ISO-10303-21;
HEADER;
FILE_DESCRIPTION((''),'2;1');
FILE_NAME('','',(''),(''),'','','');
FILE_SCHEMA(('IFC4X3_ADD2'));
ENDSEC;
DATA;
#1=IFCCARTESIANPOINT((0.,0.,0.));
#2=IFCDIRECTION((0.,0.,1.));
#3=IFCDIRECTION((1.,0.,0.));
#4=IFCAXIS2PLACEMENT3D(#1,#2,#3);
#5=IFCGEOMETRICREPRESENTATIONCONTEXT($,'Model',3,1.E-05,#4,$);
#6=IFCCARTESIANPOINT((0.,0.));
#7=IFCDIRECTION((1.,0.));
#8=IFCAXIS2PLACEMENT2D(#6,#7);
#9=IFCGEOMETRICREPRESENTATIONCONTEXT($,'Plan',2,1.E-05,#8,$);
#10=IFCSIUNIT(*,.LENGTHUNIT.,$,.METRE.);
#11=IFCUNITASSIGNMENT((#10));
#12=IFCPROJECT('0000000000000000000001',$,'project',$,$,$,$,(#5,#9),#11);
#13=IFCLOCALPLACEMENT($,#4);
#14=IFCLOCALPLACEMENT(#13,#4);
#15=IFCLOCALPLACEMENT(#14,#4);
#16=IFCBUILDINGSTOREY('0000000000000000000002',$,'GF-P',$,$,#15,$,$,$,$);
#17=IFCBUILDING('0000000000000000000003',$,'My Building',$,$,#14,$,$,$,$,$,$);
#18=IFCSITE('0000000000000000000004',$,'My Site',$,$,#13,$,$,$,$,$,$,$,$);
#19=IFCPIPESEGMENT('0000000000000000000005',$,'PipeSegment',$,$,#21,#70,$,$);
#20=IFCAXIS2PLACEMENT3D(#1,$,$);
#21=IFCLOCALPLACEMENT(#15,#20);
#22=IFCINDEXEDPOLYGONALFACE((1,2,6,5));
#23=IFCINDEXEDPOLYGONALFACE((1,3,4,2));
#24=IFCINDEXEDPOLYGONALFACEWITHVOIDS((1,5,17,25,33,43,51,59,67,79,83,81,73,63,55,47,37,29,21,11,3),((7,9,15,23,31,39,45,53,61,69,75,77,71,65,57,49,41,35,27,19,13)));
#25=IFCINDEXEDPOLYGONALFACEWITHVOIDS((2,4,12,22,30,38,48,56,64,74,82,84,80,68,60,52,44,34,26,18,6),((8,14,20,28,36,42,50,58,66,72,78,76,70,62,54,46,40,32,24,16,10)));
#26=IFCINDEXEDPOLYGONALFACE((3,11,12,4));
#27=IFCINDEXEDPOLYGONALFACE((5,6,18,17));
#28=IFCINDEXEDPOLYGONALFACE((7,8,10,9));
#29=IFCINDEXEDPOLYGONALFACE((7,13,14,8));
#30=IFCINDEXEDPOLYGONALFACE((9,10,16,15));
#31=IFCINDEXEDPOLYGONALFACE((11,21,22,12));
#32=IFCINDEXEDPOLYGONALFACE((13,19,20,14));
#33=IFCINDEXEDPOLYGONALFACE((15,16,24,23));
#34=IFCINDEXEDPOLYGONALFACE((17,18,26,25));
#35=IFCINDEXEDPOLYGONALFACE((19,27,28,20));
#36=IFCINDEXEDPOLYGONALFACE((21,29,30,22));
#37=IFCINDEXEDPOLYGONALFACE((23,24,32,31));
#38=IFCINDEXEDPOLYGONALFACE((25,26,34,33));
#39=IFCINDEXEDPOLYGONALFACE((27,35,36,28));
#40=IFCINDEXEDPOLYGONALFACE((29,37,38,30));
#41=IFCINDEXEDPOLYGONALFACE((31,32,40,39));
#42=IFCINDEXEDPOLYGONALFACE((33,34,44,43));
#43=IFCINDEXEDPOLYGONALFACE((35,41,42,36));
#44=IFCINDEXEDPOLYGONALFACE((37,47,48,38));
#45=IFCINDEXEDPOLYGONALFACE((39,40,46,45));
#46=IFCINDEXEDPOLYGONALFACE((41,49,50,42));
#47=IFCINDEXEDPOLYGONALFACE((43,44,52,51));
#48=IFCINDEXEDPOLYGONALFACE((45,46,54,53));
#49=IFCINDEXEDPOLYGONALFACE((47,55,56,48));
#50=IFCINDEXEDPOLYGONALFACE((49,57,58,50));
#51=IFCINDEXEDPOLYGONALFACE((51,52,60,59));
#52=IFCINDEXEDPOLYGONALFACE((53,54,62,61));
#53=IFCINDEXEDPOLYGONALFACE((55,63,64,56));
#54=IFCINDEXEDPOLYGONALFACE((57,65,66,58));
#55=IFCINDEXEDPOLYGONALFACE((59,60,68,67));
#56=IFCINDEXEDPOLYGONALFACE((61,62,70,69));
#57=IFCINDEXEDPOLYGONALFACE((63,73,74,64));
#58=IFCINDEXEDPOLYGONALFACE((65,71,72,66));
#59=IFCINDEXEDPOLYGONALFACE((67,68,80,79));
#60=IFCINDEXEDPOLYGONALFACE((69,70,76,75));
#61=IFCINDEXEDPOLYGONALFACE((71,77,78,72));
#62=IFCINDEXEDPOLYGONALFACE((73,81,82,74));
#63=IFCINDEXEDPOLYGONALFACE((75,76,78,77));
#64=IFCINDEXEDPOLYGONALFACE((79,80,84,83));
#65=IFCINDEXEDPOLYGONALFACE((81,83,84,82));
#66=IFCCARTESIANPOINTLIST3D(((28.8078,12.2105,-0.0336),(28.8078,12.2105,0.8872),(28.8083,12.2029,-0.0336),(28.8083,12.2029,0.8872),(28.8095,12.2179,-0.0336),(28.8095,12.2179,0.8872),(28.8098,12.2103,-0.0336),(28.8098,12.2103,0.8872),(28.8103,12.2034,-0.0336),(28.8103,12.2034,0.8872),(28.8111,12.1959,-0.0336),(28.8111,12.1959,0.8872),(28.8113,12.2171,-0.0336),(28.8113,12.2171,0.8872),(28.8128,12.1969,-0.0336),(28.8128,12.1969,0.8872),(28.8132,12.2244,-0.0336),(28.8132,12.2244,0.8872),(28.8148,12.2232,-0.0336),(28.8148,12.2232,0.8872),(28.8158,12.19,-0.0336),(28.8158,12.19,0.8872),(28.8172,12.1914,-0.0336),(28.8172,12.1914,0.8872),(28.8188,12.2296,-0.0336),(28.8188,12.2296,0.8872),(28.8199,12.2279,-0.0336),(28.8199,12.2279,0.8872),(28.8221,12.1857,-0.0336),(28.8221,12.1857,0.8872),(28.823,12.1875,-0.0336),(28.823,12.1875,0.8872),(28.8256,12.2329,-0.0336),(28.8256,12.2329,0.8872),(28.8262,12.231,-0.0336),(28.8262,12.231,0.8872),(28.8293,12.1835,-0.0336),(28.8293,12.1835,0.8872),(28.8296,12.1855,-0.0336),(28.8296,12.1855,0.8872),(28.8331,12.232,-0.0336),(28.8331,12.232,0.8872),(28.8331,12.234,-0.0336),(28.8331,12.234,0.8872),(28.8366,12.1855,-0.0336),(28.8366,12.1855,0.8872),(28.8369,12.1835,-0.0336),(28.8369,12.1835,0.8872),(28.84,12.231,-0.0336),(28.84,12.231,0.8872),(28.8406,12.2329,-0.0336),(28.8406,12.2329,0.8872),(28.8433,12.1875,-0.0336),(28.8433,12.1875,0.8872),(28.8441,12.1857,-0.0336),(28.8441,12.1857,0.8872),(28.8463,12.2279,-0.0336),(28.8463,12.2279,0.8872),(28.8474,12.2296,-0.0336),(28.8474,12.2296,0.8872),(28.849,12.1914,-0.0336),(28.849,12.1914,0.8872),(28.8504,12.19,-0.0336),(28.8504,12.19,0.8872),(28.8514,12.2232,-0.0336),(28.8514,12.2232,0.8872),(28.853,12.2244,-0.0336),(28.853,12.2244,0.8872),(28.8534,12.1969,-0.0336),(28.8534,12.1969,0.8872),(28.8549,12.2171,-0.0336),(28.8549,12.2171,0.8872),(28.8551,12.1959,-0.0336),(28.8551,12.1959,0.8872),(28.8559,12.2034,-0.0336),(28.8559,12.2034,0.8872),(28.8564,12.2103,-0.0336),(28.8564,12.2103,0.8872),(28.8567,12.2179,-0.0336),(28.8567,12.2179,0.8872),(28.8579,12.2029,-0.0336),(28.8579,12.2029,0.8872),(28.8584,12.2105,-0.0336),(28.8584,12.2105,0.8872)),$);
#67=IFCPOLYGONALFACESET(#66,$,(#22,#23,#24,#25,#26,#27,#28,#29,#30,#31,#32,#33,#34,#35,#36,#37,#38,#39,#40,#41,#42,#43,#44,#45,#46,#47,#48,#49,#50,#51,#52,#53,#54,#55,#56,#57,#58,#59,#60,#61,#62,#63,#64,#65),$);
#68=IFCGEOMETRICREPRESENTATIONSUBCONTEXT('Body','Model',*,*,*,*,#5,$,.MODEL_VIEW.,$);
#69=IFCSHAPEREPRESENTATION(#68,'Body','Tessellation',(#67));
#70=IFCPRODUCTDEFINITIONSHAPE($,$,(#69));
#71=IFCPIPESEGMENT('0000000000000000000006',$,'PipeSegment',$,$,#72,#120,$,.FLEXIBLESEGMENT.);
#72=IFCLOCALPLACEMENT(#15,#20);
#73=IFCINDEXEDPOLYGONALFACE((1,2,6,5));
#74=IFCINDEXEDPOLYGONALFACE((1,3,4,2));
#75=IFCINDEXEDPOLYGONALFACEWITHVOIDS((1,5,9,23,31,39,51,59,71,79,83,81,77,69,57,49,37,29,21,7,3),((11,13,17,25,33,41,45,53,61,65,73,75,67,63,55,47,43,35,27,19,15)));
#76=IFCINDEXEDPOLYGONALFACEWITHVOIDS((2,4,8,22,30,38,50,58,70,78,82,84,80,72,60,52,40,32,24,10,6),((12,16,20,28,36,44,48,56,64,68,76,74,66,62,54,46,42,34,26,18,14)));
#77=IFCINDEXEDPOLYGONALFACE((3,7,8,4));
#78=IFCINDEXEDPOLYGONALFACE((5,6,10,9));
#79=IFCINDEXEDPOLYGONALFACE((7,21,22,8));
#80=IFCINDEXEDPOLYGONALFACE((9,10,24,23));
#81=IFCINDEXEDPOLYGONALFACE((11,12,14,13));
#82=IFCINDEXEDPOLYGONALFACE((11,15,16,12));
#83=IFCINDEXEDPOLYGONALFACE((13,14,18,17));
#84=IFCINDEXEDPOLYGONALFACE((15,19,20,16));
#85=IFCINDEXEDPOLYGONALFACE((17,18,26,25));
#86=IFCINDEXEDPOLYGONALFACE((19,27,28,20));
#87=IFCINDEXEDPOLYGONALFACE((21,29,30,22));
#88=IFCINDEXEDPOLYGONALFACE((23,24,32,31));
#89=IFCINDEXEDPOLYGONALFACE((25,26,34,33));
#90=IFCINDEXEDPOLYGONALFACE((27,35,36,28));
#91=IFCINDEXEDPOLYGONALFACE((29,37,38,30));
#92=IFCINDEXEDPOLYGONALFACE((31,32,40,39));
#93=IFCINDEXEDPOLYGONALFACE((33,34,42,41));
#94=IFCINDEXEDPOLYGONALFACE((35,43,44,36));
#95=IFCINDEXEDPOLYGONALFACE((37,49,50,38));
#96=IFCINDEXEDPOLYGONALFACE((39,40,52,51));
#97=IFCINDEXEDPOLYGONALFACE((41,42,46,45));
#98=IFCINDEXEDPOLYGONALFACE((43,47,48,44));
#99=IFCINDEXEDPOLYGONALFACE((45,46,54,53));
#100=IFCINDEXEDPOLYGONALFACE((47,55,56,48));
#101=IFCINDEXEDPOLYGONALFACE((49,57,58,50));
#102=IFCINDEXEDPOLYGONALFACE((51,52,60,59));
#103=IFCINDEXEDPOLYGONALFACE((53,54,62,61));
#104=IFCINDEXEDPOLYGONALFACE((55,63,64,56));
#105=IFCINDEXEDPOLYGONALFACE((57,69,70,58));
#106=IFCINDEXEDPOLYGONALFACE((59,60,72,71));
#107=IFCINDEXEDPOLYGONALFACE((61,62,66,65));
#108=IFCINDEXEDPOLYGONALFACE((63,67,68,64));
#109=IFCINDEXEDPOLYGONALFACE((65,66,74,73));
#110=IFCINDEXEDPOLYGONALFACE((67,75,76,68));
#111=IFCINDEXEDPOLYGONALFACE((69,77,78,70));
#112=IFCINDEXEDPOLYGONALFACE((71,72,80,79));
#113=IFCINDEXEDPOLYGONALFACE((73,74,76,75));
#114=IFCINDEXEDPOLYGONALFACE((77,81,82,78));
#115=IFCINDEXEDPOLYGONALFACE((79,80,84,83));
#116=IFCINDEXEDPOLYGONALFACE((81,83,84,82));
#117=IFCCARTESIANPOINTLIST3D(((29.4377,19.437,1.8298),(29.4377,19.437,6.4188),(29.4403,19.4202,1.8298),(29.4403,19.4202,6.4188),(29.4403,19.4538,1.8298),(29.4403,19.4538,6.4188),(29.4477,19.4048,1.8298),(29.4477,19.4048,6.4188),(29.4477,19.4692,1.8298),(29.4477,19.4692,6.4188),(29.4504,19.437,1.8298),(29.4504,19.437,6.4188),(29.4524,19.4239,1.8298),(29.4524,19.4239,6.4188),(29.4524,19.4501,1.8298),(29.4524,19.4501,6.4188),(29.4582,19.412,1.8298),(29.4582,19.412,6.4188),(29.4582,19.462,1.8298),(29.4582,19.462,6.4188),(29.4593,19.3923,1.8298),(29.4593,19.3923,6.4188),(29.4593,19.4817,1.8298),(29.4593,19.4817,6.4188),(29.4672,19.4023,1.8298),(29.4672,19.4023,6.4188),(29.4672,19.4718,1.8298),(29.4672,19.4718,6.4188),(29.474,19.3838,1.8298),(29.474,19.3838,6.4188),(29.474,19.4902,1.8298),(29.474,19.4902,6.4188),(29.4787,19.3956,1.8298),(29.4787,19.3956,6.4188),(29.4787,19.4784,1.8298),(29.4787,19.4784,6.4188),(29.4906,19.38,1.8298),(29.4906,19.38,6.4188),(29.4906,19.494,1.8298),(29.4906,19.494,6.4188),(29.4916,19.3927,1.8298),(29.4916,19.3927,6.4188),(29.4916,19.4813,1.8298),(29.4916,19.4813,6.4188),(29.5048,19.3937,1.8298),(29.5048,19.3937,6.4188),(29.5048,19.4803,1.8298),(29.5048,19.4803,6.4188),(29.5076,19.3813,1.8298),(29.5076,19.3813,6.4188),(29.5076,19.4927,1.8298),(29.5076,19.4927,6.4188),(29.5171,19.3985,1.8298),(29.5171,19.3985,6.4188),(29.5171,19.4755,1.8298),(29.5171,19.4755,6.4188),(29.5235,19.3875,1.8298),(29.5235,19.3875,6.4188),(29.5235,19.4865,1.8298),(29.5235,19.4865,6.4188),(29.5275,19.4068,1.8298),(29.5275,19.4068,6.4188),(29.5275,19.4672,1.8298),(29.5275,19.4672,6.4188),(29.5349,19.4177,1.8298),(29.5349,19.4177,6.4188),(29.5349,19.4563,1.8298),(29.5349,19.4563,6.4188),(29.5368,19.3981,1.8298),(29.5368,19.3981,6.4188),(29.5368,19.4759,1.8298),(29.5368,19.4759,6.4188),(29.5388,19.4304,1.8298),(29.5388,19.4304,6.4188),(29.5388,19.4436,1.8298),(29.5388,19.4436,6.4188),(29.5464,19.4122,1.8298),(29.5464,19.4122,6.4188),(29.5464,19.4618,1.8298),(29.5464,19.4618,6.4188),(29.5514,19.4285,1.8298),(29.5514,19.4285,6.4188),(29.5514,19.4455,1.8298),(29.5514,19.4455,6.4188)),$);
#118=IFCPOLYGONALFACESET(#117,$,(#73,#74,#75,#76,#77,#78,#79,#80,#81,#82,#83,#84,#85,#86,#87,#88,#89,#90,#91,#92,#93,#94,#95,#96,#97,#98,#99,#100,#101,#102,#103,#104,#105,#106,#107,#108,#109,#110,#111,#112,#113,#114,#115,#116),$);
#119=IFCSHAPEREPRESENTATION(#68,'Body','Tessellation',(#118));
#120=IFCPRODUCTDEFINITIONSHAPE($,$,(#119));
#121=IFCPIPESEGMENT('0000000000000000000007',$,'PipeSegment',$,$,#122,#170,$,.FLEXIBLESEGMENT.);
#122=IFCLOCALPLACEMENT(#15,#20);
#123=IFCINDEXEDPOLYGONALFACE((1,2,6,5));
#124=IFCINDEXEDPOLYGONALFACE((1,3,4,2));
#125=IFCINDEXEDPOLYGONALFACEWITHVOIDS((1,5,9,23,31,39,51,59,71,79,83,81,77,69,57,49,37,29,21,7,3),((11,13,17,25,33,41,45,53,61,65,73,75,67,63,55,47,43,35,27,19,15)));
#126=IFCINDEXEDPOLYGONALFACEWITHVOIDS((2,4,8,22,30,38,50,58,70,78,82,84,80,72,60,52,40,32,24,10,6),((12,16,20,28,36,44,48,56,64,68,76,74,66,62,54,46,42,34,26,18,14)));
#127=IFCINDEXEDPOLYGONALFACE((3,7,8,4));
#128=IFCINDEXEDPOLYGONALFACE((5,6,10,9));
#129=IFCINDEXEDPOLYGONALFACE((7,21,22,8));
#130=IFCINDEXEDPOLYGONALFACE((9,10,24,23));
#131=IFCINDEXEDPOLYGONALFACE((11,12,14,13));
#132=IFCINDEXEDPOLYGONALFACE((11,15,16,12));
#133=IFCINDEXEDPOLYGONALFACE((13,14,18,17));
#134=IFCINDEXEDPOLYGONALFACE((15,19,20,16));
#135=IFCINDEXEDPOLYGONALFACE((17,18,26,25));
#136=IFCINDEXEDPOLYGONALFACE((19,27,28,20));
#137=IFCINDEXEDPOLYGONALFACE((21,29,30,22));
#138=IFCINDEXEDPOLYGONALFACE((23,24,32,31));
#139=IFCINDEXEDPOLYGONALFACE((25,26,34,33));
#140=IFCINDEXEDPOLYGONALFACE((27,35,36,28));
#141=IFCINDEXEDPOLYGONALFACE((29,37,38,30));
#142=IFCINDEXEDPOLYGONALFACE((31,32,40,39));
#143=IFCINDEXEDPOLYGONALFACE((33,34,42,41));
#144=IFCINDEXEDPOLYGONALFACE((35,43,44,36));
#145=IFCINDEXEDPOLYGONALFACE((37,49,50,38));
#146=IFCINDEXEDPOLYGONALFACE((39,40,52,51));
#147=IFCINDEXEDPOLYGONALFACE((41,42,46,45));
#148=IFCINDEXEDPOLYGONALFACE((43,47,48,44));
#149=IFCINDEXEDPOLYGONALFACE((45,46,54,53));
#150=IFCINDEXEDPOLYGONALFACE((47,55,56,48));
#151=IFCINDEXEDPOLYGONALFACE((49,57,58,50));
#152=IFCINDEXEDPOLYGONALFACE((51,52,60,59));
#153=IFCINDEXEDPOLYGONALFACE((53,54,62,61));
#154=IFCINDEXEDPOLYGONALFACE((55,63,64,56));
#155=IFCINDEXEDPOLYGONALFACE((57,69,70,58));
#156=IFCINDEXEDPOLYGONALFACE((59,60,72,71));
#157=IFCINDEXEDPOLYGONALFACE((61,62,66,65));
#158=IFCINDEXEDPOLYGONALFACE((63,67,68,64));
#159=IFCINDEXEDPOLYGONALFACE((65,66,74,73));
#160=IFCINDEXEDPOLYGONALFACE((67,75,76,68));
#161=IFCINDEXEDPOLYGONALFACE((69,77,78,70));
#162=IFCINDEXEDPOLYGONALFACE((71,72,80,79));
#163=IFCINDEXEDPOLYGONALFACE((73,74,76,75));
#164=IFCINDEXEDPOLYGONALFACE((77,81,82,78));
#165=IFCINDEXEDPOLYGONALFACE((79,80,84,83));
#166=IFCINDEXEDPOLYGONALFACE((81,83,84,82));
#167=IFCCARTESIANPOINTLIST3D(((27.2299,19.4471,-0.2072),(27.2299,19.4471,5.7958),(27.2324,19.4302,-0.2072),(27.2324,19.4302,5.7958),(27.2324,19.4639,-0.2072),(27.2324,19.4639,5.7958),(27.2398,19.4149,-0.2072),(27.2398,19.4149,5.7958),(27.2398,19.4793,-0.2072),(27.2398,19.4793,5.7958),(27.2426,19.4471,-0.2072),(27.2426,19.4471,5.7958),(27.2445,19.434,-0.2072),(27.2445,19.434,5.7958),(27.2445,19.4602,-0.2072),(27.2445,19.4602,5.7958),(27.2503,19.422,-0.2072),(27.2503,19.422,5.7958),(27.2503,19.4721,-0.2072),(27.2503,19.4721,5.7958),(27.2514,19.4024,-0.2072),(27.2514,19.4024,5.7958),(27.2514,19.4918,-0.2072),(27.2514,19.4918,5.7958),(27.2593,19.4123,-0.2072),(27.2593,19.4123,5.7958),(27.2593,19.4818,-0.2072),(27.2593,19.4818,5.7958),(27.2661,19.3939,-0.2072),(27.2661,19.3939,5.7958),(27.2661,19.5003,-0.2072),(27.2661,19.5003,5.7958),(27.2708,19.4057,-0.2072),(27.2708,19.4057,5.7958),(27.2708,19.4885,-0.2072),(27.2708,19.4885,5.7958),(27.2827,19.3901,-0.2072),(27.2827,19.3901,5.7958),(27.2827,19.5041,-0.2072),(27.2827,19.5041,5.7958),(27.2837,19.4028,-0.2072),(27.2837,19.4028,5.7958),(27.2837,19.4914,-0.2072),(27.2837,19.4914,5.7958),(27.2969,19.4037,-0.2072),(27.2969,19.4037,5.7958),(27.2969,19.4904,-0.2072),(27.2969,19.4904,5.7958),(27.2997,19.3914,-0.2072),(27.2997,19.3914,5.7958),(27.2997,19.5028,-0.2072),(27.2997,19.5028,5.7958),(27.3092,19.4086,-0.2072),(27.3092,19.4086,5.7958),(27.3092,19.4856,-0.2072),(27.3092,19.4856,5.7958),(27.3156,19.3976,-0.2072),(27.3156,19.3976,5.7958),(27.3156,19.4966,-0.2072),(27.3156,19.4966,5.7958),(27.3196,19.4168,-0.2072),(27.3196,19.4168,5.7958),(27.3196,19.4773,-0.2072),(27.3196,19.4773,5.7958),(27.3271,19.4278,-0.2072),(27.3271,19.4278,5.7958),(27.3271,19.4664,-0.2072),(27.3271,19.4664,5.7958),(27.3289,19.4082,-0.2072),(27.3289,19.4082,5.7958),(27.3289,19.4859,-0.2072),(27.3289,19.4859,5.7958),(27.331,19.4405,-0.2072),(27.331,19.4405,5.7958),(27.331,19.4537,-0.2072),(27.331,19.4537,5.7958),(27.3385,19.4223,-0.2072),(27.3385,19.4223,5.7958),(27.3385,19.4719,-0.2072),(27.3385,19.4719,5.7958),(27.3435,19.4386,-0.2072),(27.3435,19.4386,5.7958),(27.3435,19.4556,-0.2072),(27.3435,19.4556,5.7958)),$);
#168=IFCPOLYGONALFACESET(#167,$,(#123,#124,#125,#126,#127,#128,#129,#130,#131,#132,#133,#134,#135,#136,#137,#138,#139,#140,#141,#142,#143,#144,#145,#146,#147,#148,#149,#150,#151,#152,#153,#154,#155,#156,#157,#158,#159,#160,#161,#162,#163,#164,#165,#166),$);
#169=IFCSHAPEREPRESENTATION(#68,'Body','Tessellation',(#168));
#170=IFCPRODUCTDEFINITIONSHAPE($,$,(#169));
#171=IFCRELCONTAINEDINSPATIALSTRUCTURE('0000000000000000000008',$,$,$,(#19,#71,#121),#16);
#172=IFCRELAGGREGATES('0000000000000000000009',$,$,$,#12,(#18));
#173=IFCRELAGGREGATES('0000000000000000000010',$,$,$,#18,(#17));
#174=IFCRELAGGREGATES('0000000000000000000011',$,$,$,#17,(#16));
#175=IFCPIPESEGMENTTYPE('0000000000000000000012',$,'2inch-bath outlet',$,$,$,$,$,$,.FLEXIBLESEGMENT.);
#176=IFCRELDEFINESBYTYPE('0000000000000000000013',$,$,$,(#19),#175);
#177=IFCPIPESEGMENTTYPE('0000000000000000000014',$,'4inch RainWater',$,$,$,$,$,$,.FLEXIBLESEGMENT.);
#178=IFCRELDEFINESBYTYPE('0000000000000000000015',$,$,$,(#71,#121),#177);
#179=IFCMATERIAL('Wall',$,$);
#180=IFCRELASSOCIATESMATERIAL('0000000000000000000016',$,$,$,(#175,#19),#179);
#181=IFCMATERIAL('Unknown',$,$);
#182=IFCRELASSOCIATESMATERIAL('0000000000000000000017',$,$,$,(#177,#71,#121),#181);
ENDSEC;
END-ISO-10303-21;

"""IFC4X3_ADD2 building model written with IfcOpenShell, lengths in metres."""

from ifc_helpers import new_model, si_unit, frame, origin_with_axes, origin_2d_with_axis, place, context, subcontext, project, spatial, hollow_circle, extrude, material, material_profile, profile_set, profile_usage, type_object, element, save


model = new_model("IFC4X3_ADD2")

# Units and contexts
model_context = context("Model", 3, precision=1e-05, world=origin_with_axes())
plan_context = context("Plan", 2, precision=1e-05, world=origin_2d_with_axis())
body_context = subcontext(model_context, "Body", "Model", "MODEL_VIEW")
ifc_project = project(units=[si_unit("LENGTHUNIT", "METRE")], contexts=[model_context, plan_context])

# Site, building, storey
site_placement = place(None, origin_with_axes())
site = spatial("IfcSite", under=ifc_project, at=site_placement, Name="My Site")
building_placement = place(site_placement, origin_with_axes())
building = spatial("IfcBuilding", under=site, at=building_placement, Name="My Building")
storey_placement = place(building_placement, origin_with_axes())
storey = spatial("IfcBuildingStorey", under=building, at=storey_placement, Name="GF-P")

# Pipe segments
ifc_material_1 = material(Name="Unknown")
ifc_material_2 = material(Name="Wall")
ifc_material_profile_1 = material_profile(ifc_material_2, hollow_circle(Radius=0.0254, WallThickness=0.002))
ifc_profile_set_1 = profile_set([ifc_material_profile_1], Name="graywater")
pipe_segment_type_1 = type_object("IfcPipeSegmentType", Name="2inch-bath outlet", PredefinedType="FLEXIBLESEGMENT", material=ifc_profile_set_1)
ifc_profile_usage_1 = profile_usage(ifc_profile_set_1, cardinal=5)
pipe_segment_1_placement = place(storey_placement, frame((28.8331, 12.2086, -0.0336), z_axis=(0.0, 0.0, 1.0), x_axis=(0.0, 1.0, 0.0)))
element("IfcPipeSegment", 1, at=pipe_segment_1_placement, inside=storey, type_object=pipe_segment_type_1, material=ifc_profile_usage_1, Name="PipeSegment", context=body_context, shape_type="SweptSolid", body=[
    extrude(hollow_circle(Radius=0.0254, WallThickness=0.002), origin_with_axes(), (0.0, 0.0, 1.0), 0.9207),
])
ifc_material_profile_2 = material_profile(ifc_material_1, hollow_circle(Radius=0.0571, WallThickness=0.0127))
ifc_profile_set_2 = profile_set([ifc_material_profile_2], Name="rainwater")
ifc_profile_usage_2 = profile_usage(ifc_profile_set_2)
pipe_segment_type_2 = type_object("IfcPipeSegmentType", Name="4inch RainWater", PredefinedType="FLEXIBLESEGMENT", material=ifc_profile_set_2)
pipe_segment_2_placement = place(storey_placement, frame((29.4949, 19.437, 1.8298), z_axis=(0.0, 0.0, 1.0), x_axis=(-1.0, 0.0, 0.0)))
element("IfcPipeSegment", 2, at=pipe_segment_2_placement, inside=storey, type_object=pipe_segment_type_2, material=ifc_profile_usage_2, Name="PipeSegment", PredefinedType="FLEXIBLESEGMENT", context=body_context, shape_type="SweptSolid", body=[
    extrude(hollow_circle(Radius=0.0571, WallThickness=0.0127), origin_with_axes(), (0.0, 0.0, 1.0), 4.589),
])
ifc_profile_usage_3 = profile_usage(ifc_profile_set_2)
pipe_segment_3_placement = place(storey_placement, frame((27.287, 19.4471, -0.2072), z_axis=(0.0, 0.0, 1.0), x_axis=(-1.0, 0.0, 0.0)))
element("IfcPipeSegment", 3, at=pipe_segment_3_placement, inside=storey, type_object=pipe_segment_type_2, material=ifc_profile_usage_3, Name="PipeSegment", PredefinedType="FLEXIBLESEGMENT", context=body_context, shape_type="SweptSolid", body=[
    extrude(hollow_circle(Radius=0.0571, WallThickness=0.0127), origin_with_axes(), (0.0, 0.0, 1.0), 6.003),
])

save(model, "model.ifc")
